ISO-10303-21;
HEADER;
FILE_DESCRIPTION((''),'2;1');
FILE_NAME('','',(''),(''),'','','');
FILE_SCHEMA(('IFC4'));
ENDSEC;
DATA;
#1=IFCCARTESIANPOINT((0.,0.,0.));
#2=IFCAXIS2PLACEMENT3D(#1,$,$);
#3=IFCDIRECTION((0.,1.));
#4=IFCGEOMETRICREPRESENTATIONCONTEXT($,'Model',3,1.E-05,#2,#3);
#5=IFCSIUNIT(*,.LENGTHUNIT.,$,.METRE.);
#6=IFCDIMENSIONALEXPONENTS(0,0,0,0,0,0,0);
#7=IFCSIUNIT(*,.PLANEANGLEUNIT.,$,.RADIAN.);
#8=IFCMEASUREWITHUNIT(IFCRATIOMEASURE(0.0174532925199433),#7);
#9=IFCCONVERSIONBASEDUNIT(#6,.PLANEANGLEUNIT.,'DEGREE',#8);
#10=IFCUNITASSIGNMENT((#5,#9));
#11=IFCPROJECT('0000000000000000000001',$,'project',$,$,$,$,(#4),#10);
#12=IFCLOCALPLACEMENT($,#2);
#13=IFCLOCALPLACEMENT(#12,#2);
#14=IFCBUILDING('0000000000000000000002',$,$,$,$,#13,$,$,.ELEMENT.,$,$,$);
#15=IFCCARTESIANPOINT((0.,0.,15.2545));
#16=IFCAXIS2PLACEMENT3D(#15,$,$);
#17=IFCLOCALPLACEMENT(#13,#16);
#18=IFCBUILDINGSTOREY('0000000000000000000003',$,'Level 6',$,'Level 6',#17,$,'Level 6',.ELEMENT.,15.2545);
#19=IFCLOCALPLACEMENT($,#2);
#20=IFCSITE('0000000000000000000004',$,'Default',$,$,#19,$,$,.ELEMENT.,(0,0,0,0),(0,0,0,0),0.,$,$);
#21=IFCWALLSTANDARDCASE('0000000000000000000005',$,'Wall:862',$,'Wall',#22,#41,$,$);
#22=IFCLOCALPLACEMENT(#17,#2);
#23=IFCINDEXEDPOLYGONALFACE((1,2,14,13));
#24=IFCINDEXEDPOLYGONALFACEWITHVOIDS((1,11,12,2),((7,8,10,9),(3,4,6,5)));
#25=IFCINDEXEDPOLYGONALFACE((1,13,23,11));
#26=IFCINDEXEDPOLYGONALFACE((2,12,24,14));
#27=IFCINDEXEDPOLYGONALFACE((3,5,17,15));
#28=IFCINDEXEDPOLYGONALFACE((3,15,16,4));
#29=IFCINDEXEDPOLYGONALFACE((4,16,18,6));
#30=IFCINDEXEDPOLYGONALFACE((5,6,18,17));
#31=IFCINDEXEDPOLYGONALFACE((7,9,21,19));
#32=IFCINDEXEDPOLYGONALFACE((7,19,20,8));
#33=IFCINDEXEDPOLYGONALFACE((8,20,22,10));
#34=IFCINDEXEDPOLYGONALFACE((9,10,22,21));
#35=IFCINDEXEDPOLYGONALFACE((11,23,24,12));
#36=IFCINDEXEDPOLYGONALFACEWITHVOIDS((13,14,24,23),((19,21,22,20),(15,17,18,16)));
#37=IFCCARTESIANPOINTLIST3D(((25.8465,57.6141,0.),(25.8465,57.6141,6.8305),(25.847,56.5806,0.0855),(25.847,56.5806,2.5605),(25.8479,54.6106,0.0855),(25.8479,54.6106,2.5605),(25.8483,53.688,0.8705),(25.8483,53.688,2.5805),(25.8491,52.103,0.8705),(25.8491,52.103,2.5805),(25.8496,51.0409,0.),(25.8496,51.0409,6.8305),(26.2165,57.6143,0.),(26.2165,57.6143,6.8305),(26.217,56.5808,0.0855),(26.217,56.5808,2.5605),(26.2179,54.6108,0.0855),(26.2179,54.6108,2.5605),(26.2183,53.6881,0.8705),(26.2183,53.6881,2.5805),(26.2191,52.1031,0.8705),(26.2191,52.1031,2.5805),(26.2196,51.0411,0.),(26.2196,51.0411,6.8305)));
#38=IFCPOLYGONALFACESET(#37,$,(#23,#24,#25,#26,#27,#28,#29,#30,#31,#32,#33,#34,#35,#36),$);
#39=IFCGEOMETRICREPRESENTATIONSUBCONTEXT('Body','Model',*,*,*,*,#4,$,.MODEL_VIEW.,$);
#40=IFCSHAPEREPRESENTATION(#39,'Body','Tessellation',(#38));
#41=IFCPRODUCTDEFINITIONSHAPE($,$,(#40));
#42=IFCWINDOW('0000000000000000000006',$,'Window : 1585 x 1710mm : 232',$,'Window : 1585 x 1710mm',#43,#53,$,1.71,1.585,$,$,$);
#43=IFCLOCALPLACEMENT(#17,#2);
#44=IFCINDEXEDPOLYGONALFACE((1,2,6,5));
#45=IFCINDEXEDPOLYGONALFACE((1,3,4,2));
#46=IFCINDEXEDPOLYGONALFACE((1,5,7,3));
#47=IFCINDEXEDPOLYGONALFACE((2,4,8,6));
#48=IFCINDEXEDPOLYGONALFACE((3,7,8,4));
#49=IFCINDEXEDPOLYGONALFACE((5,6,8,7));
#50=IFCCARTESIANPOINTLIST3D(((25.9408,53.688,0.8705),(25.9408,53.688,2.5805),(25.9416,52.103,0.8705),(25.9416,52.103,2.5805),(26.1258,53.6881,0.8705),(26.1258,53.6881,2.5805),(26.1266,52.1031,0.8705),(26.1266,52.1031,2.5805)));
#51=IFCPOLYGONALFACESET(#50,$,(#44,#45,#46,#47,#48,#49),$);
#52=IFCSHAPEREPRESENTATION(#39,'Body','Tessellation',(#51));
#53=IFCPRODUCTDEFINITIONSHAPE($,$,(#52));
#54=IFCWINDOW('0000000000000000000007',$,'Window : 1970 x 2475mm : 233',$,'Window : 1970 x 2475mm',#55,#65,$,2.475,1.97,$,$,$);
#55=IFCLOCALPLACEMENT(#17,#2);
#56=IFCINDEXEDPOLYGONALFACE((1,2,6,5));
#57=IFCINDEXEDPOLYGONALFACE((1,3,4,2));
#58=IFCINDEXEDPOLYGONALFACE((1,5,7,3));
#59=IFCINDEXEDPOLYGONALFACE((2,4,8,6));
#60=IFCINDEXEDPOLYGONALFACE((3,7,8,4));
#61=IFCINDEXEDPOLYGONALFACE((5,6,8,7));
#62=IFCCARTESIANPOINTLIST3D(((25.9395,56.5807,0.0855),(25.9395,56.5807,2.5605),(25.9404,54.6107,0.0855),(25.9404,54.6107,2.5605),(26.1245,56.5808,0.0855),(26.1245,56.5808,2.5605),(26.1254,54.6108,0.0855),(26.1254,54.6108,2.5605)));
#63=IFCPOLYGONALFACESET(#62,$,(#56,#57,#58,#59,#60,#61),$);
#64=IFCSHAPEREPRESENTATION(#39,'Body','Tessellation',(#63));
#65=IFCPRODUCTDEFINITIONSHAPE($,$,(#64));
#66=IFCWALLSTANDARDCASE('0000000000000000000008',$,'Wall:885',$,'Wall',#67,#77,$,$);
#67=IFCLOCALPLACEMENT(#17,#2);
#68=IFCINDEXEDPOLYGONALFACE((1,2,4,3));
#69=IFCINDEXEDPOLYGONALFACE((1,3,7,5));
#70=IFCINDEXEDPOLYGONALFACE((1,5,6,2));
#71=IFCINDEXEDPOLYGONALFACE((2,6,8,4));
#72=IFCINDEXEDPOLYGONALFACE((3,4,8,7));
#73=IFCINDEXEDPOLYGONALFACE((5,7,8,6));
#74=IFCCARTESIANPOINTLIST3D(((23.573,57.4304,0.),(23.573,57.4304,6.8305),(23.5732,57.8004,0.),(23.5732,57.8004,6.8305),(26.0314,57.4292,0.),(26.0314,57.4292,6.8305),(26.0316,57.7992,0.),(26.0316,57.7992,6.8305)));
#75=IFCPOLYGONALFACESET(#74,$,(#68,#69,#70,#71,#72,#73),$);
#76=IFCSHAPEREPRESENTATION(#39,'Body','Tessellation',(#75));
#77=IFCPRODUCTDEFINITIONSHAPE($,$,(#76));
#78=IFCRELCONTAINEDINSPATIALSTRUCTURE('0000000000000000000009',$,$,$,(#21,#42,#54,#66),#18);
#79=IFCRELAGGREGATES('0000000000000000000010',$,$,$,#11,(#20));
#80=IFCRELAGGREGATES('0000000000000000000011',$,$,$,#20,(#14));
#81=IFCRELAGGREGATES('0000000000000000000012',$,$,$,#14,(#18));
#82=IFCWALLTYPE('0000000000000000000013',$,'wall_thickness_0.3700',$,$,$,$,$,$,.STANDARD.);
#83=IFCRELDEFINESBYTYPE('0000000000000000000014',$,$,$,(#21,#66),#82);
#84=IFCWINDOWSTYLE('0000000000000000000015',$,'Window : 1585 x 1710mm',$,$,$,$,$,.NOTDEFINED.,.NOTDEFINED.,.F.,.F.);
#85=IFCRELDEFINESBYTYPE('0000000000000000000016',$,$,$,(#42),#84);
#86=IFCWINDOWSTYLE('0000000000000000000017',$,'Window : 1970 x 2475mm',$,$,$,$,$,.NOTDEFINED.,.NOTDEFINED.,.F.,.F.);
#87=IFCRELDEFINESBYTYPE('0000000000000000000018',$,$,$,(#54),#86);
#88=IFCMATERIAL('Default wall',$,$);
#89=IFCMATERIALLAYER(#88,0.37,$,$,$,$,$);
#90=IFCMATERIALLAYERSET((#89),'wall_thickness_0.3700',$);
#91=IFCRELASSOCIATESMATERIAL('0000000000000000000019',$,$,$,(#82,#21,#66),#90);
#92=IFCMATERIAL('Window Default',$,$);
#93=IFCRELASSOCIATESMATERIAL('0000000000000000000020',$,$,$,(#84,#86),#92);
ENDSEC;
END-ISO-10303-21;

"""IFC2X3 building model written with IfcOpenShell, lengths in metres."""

from ifc_helpers import new_model, entity, si_unit, converted_unit, direction, frame, frame_2d, origin, origin_2d_with_axis, place, context, subcontext, project, spatial, polyline, rectangle, outline, extrude, source, transform, mapped, material, layer, layer_set, layer_usage, type_object, type_shapes, element, fill, save


model = new_model("IFC2X3")

# Units and contexts
model_context = context("Model", 3, precision=1e-05, world=origin(), true_north=direction((0.0, 1.0)))
body_context = subcontext(model_context, "Body", "Model", "MODEL_VIEW")
ifc_project = project(units=[si_unit("LENGTHUNIT", "METRE"), converted_unit("PLANEANGLEUNIT", "DEGREE", entity("IfcRatioMeasure", 0.0174532925199433), si_unit("PLANEANGLEUNIT", "RADIAN"), dimensions=[0, 0, 0, 0, 0, 0, 0])], contexts=[model_context])

# Site, building, storey
site_placement = place(None, origin())
site = spatial("IfcSite", under=ifc_project, at=site_placement, Name="Default", CompositionType="ELEMENT", RefLatitude=(0, 0, 0, 0), RefLongitude=(0, 0, 0, 0), RefElevation=0.0)
placement_1 = place(None, origin())
building_placement = place(placement_1, origin())
building = spatial("IfcBuilding", under=site, at=building_placement, CompositionType="ELEMENT")
storey_placement = place(building_placement, frame((0.0, 0.0, 15.2545)))
storey = spatial("IfcBuildingStorey", under=building, at=storey_placement, Name="Level 6", ObjectType="Level 6", LongName="Level 6", CompositionType="ELEMENT", Elevation=15.2545)

# Wall, openings, windows
ifc_material_1 = material(Name="Default wall")
ifc_layer_1 = layer(ifc_material_1, 0.37)
ifc_layer_set_1 = layer_set([ifc_layer_1], Name="wall_thickness_0.3700")
ifc_layer_usage_1 = layer_usage(ifc_layer_set_1, "AXIS2", "POSITIVE", -0.185)
wall_type_1 = type_object("IfcWallType", Name="wall_thickness_0.3700", PredefinedType="STANDARD", material=ifc_layer_set_1)
wall_1_placement = place(storey_placement, frame((26.0315, 57.6142, 0.0), z_axis=(0.0, 0.0, 1.0), x_axis=(0.000469, -1.0, 0.0)))
wall_1 = element("IfcWallStandardCase", 1, at=wall_1_placement, inside=storey, type_object=wall_type_1, material=ifc_layer_usage_1, Name="Wall:862", ObjectType="Wall", context=body_context, shape_type="SweptSolid", body=[
    extrude(outline(polyline([(6.5732, -0.185), (6.5732, 0.185), (0.0, 0.185), (0.0, -0.185), (6.5732, -0.185)])), origin(), (0.0, 0.0, 1.0), 6.8305),
])
opening_1_placement = place(wall_1_placement, frame((3.9261, -0.185, 0.8705)))
opening_1 = element("IfcOpeningElement", 2, at=opening_1_placement, cuts=wall_1, ObjectType="Opening", context=body_context, shape_type="SweptSolid", body=[
    extrude(rectangle(XDim=1.585, YDim=1.71, at=frame_2d((0.855, 0.7925), x_axis=(0.0, 1.0))), frame((0.0, 0.0, 0.0), z_axis=(0.0, 1.0, 0.0), x_axis=(0.0, 0.0, 1.0)), (0.0, 0.0, 1.0), 0.37),
])
opening_2_placement = place(wall_1_placement, frame((1.0335, -0.185, 0.0855)))
opening_2 = element("IfcOpeningElement", 3, at=opening_2_placement, cuts=wall_1, ObjectType="Opening", context=body_context, shape_type="SweptSolid", body=[
    extrude(rectangle(XDim=1.97, YDim=2.475, at=frame_2d((1.2375, 0.985), x_axis=(0.0, 1.0))), frame((0.0, 0.0, 0.0), z_axis=(0.0, 1.0, 0.0), x_axis=(0.0, 0.0, 1.0)), (0.0, 0.0, 1.0), 0.37),
])
ifc_material_2 = material(Name="Window Default")
window_style_1 = type_object("IfcWindowStyle", Name="Window : 1585 x 1710mm", ConstructionType="NOTDEFINED", OperationType="NOTDEFINED", ParameterTakesPrecedence=False, Sizeable=False, material=ifc_material_2)
shared_shape_1 = source(origin(), body_context, "Body", "SweptSolid", [
    extrude(rectangle(XDim=0.185, YDim=1.585, at=origin_2d_with_axis()), frame((0.7925, 0.185, 0.0), z_axis=(0.0, 0.0, 1.0), x_axis=(0.0, 1.0, 0.0)), (0.0, 0.0, 1.0), 1.71),
])
type_shapes(window_style_1, [shared_shape_1])
window_1_placement = place(opening_1_placement, origin())
window_1 = element("IfcWindow", 4, at=window_1_placement, inside=storey, type_object=window_style_1, Name="Window : 1585 x 1710mm : 232", ObjectType="Window : 1585 x 1710mm", OverallHeight=1.71, OverallWidth=1.585, context=body_context, shape_type="MappedRepresentation", body=[
    mapped(shared_shape_1, transform((0.0, 0.0, 0.0), scale=1.0)),
])
fill(opening_1, window_1)
window_style_2 = type_object("IfcWindowStyle", Name="Window : 1970 x 2475mm", ConstructionType="NOTDEFINED", OperationType="NOTDEFINED", ParameterTakesPrecedence=False, Sizeable=False, material=ifc_material_2)
shared_shape_2 = source(origin(), body_context, "Body", "SweptSolid", [
    extrude(rectangle(XDim=0.185, YDim=1.97, at=origin_2d_with_axis()), frame((0.985, 0.185, 0.0), z_axis=(0.0, 0.0, 1.0), x_axis=(0.0, 1.0, 0.0)), (0.0, 0.0, 1.0), 2.475),
])
type_shapes(window_style_2, [shared_shape_2])
window_2_placement = place(opening_2_placement, origin())
window_2 = element("IfcWindow", 5, at=window_2_placement, inside=storey, type_object=window_style_2, Name="Window : 1970 x 2475mm : 233", ObjectType="Window : 1970 x 2475mm", OverallHeight=2.475, OverallWidth=1.97, context=body_context, shape_type="MappedRepresentation", body=[
    mapped(shared_shape_2, transform((0.0, 0.0, 0.0), scale=1.0)),
])
fill(opening_2, window_2)

# Wall
wall_2_placement = place(storey_placement, frame((23.5731, 57.6154, 0.0), z_axis=(0.0, 0.0, 1.0), x_axis=(1.0, -0.000497, 0.0)))
element("IfcWallStandardCase", 6, at=wall_2_placement, inside=storey, type_object=wall_type_1, material=ifc_layer_usage_1, Name="Wall:885", ObjectType="Wall", context=body_context, shape_type="SweptSolid", body=[
    extrude(outline(polyline([(2.4584, -0.185), (2.4584, 0.185), (0.0, 0.185), (0.0, -0.185), (2.4584, -0.185)])), origin(), (0.0, 0.0, 1.0), 6.8305),
])

save(model, "model.ifc")
